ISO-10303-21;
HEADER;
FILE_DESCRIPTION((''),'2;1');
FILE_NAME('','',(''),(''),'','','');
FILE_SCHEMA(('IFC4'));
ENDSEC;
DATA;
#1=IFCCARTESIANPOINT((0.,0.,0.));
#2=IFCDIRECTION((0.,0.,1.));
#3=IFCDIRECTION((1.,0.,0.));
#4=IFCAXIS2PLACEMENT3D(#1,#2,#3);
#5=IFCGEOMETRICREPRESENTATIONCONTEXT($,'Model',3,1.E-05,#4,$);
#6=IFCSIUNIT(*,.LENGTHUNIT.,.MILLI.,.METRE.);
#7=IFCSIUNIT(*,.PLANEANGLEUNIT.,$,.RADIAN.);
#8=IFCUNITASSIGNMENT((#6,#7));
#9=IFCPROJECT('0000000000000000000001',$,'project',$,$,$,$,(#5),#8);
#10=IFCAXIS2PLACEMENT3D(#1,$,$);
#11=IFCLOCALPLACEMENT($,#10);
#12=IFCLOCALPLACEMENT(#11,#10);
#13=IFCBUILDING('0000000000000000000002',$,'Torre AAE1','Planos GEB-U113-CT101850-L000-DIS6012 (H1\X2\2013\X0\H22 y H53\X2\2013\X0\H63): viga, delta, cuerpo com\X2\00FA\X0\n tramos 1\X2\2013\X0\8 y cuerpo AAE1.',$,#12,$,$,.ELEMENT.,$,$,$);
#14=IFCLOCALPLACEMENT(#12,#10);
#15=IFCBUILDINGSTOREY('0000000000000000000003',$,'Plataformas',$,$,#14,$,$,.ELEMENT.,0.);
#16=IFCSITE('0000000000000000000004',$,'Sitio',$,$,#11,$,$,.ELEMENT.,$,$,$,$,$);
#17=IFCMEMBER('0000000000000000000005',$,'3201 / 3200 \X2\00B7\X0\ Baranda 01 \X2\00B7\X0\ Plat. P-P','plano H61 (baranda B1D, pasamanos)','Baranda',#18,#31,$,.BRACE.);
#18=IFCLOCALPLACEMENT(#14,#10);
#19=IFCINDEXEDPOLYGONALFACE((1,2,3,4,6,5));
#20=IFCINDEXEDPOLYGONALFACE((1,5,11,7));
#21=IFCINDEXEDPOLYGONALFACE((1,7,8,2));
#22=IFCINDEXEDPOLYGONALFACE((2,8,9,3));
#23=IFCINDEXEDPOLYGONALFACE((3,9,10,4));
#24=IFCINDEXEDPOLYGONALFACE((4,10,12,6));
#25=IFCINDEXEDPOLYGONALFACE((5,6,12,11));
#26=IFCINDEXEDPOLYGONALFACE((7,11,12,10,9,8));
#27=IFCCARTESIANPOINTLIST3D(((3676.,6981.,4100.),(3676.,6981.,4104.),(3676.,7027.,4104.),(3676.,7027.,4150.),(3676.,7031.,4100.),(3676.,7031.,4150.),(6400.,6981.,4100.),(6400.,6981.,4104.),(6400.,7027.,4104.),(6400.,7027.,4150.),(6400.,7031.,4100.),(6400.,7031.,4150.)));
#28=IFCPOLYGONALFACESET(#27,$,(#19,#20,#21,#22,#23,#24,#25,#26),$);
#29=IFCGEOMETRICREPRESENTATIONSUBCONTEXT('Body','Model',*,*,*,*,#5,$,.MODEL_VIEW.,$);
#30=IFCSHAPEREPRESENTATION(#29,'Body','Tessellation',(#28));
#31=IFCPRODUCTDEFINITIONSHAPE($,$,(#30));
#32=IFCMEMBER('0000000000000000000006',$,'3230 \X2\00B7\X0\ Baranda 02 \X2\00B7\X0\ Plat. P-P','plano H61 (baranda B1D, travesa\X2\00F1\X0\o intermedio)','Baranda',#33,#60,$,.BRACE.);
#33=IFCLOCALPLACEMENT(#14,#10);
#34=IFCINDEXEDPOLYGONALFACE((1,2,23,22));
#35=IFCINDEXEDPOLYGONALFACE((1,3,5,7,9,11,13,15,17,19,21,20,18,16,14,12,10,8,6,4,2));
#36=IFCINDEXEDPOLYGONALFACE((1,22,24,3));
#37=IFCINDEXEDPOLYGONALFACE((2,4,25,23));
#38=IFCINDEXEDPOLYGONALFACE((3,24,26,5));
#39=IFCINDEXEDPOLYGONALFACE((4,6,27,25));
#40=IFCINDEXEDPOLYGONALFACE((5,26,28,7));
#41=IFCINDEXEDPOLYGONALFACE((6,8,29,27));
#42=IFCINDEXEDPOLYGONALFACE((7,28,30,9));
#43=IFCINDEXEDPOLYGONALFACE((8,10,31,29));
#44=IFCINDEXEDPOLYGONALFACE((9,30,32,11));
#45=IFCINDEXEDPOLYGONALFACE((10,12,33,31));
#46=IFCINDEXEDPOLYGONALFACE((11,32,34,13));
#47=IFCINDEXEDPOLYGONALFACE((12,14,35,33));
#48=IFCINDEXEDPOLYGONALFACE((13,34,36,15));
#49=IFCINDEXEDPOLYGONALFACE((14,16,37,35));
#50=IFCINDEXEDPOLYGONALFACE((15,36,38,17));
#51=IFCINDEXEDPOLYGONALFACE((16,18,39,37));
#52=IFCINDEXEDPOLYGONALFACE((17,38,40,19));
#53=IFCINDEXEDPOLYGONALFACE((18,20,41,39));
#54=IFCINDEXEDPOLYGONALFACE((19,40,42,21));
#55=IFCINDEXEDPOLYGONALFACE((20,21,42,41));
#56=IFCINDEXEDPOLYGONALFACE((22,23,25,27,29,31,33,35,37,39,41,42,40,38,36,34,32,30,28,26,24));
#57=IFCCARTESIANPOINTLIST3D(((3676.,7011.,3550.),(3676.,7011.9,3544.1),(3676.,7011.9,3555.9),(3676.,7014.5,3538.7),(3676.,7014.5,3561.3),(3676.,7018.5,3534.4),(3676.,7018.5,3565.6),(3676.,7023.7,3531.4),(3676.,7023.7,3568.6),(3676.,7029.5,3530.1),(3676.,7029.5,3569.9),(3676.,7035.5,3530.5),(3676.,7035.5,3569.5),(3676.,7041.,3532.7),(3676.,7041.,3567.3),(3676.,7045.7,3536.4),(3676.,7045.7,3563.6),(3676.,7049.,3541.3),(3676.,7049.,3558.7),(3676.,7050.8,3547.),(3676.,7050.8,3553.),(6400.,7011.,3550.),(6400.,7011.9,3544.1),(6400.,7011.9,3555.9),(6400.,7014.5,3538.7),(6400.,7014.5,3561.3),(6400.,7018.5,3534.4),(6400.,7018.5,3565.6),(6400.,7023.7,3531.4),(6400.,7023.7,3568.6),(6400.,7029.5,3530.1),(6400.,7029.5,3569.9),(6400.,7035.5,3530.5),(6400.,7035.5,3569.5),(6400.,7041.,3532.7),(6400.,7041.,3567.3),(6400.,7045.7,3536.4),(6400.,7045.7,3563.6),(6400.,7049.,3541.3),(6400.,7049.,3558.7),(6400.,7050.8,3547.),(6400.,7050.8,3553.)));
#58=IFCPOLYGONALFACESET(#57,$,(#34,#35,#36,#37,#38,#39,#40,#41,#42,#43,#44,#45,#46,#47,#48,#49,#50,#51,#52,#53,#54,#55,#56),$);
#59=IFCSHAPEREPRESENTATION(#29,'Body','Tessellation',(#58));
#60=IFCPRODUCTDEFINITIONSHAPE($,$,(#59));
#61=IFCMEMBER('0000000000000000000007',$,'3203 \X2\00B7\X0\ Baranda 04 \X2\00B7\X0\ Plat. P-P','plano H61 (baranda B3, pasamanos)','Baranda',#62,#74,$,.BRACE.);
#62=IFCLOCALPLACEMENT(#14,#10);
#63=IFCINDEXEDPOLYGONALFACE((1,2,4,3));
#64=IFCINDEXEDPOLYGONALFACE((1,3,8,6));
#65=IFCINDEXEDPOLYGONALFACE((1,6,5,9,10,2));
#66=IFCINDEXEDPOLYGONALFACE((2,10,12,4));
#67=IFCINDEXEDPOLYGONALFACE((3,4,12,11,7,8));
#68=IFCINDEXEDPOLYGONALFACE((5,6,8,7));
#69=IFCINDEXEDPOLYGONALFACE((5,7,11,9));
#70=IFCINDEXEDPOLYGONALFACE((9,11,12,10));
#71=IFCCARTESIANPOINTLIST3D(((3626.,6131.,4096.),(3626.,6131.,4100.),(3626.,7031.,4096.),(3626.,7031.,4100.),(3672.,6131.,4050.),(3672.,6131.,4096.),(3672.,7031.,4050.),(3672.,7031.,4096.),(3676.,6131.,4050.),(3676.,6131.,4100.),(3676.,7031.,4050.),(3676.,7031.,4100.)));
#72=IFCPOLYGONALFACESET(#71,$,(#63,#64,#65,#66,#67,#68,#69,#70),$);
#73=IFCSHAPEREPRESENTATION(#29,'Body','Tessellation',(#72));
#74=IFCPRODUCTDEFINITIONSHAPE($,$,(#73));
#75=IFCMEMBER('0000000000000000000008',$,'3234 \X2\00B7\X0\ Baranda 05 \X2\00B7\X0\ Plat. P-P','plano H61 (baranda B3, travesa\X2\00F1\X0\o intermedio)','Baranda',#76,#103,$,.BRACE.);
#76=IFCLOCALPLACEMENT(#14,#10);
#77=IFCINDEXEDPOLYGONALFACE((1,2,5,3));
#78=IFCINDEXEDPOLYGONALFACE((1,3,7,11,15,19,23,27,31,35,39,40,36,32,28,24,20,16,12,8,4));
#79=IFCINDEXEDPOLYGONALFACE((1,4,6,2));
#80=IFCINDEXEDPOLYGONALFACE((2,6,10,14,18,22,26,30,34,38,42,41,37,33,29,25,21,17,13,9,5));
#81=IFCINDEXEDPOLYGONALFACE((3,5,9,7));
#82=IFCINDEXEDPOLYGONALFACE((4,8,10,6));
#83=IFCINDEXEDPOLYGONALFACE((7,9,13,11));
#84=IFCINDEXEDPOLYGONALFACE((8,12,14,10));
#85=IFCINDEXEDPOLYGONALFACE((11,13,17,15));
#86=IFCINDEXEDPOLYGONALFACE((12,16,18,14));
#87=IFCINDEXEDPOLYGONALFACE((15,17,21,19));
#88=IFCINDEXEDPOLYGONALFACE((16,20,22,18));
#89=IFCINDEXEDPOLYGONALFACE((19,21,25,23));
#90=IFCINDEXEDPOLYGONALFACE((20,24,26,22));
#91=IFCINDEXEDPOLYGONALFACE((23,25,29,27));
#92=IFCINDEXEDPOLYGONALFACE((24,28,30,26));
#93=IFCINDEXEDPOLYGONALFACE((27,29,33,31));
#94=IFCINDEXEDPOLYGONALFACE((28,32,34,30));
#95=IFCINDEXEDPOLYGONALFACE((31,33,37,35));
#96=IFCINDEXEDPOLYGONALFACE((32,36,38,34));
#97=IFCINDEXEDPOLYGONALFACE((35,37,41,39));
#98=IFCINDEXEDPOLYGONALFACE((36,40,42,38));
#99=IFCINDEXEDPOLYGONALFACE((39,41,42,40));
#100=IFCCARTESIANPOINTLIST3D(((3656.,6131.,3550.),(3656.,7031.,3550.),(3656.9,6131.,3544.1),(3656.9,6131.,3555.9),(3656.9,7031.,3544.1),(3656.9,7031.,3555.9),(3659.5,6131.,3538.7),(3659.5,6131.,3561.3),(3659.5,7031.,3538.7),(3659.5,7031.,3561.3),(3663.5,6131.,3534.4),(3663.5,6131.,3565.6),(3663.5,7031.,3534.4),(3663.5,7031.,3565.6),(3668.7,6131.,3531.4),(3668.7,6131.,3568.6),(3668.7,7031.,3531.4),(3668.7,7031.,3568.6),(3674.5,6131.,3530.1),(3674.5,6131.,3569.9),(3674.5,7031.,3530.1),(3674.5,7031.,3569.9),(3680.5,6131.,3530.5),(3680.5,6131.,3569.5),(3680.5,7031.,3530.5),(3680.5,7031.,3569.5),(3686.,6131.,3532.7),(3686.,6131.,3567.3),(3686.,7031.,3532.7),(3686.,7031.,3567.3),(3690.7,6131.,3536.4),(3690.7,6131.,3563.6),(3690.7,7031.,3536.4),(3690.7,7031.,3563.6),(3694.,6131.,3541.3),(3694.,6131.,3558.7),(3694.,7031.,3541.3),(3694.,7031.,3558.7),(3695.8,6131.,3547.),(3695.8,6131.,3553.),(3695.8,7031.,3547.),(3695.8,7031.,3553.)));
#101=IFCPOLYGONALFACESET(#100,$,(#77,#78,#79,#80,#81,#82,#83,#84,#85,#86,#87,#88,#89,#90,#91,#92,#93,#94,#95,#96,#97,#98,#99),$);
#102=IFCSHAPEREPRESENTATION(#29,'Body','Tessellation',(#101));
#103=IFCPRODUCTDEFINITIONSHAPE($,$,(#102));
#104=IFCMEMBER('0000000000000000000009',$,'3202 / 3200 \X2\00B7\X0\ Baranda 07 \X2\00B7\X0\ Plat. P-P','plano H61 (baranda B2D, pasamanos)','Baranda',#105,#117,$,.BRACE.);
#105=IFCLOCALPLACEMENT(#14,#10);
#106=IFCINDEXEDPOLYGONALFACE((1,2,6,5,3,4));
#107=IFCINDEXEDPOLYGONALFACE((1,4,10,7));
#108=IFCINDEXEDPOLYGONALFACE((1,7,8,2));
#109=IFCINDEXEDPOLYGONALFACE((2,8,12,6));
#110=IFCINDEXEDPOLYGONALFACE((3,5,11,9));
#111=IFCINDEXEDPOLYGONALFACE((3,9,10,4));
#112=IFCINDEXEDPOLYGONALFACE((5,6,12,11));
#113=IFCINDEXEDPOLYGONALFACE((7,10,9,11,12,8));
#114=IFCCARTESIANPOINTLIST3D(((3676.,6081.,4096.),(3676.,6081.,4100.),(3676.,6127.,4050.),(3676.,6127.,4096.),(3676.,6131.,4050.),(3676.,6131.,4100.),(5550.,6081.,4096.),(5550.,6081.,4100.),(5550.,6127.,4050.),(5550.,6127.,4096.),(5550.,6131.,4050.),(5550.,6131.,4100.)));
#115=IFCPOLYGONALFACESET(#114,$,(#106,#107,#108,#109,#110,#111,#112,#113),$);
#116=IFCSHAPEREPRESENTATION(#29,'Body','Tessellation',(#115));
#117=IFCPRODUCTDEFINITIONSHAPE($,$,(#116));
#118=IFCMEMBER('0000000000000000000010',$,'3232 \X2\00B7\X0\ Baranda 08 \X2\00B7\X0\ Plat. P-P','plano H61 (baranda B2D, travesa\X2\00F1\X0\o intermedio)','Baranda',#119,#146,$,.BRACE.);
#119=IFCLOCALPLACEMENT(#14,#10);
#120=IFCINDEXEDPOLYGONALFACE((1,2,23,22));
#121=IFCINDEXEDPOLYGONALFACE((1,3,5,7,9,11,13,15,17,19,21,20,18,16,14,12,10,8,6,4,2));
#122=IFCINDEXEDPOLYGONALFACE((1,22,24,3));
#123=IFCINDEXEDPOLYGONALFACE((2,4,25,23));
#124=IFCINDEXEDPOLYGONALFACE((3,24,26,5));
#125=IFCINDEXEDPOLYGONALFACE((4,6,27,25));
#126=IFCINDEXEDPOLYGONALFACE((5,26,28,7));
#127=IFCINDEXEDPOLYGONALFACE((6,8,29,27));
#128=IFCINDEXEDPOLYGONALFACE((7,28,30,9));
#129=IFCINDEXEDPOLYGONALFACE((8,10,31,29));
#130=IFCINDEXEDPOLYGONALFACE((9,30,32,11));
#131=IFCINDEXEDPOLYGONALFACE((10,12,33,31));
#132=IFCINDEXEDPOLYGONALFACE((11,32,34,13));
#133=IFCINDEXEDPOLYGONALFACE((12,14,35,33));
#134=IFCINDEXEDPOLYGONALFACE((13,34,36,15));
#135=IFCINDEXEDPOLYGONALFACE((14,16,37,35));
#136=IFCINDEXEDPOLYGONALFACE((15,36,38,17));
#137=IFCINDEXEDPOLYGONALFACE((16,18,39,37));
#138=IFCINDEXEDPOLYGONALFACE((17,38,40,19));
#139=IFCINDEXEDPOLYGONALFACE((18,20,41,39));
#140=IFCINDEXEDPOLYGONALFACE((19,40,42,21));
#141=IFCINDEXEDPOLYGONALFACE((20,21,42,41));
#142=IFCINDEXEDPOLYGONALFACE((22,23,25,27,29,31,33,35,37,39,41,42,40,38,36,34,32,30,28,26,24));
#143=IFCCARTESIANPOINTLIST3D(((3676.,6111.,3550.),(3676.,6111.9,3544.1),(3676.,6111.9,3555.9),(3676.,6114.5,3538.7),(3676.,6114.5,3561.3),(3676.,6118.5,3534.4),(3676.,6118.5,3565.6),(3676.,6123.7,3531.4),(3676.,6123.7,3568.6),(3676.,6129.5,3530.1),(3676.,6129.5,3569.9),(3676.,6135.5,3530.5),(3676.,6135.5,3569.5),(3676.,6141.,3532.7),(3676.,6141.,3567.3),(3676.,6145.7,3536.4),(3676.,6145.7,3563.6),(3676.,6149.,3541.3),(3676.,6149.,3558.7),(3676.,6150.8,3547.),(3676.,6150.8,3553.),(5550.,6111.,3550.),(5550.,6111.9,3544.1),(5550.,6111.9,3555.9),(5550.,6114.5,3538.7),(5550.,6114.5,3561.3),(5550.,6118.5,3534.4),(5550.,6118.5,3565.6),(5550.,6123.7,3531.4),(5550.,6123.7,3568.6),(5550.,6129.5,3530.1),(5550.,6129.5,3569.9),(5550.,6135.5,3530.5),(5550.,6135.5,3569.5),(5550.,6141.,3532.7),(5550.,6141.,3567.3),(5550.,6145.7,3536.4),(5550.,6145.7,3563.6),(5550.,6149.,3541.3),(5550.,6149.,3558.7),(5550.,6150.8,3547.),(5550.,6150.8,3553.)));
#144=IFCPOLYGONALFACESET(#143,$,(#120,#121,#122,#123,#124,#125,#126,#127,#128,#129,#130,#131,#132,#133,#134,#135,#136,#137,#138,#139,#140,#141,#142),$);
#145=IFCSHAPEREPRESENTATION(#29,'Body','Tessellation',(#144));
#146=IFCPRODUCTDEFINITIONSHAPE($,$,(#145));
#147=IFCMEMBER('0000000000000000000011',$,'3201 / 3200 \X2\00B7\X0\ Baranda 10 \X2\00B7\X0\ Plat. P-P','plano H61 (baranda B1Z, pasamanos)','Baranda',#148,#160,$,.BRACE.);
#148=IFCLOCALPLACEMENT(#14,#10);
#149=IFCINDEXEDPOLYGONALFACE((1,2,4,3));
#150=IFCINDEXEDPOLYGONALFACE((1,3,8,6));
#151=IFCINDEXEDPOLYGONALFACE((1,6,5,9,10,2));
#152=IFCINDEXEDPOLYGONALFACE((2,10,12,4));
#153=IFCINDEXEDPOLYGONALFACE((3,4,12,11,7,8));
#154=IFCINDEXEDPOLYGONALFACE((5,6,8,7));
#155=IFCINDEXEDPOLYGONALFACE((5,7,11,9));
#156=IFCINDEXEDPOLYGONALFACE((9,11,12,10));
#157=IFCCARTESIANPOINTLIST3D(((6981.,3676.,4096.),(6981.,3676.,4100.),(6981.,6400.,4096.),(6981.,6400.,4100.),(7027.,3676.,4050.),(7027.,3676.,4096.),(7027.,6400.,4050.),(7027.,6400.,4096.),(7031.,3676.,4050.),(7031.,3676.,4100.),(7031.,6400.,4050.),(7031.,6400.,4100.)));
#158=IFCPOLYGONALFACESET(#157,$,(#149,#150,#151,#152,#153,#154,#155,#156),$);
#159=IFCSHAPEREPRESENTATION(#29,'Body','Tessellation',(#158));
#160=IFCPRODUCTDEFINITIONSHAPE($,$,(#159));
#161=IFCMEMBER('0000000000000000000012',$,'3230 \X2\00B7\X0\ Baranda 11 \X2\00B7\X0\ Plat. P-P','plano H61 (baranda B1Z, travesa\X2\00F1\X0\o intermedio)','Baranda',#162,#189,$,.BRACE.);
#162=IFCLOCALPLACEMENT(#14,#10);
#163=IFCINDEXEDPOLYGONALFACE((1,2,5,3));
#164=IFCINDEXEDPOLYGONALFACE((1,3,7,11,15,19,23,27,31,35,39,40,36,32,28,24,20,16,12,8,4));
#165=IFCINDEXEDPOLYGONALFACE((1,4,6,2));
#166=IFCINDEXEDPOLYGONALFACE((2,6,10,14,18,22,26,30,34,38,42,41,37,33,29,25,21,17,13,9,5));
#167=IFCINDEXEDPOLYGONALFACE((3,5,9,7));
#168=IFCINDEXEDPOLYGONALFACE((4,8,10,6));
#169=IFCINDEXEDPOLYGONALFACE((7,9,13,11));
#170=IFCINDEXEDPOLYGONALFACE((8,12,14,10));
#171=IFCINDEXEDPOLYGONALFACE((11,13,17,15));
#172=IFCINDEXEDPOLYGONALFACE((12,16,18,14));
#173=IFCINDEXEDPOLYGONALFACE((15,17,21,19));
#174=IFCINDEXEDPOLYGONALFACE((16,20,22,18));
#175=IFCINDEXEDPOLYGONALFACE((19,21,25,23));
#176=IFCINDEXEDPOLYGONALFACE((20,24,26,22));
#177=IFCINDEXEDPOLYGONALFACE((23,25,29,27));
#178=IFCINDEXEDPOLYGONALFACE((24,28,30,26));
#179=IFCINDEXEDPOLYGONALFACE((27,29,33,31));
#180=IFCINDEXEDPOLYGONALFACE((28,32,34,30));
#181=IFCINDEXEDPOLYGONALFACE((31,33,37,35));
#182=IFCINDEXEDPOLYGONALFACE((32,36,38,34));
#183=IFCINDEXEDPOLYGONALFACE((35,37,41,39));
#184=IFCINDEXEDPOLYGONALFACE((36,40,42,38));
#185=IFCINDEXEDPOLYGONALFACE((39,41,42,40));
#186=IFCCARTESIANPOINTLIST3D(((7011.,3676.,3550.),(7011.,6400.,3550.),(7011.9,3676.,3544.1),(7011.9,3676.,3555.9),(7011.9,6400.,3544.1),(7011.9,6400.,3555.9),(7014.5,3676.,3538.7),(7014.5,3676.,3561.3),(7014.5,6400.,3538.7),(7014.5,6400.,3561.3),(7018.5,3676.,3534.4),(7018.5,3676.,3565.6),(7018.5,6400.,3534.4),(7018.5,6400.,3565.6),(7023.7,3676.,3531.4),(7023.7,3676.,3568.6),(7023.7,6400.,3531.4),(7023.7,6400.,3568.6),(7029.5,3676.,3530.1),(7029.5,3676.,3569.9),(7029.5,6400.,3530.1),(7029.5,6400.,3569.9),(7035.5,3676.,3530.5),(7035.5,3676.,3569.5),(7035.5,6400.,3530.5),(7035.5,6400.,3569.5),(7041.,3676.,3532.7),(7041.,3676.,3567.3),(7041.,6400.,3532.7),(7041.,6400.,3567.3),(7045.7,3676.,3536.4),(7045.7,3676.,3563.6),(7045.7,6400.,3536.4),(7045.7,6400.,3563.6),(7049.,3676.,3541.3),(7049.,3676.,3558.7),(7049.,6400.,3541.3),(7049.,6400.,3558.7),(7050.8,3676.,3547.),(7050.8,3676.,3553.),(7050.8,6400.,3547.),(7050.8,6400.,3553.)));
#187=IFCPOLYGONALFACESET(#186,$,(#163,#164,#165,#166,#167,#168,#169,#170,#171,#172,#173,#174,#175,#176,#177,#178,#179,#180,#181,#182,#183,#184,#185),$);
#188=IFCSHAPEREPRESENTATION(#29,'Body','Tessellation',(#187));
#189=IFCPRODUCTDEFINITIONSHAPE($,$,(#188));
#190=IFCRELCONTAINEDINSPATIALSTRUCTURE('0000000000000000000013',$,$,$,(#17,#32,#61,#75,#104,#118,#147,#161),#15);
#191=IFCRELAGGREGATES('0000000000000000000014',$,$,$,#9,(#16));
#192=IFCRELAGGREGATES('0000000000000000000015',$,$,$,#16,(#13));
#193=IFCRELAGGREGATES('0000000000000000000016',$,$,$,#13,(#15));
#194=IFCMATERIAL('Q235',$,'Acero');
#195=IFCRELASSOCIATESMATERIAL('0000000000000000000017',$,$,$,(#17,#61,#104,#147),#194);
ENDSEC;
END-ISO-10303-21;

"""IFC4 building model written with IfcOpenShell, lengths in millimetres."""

from ifc_helpers import new_model, si_unit, frame, frame_2d, origin, origin_with_axes, place, context, subcontext, project, spatial, circle, l_section, extrude, material, element, save


model = new_model("IFC4")

# Units and contexts
model_context = context("Model", 3, precision=1e-05, world=origin_with_axes())
body_context = subcontext(model_context, "Body", "Model", "MODEL_VIEW")
ifc_project = project(units=[si_unit("LENGTHUNIT", "METRE", prefix="MILLI"), si_unit("PLANEANGLEUNIT", "RADIAN")], contexts=[model_context])

# Site, building, storey
site_placement = place(None, origin())
site = spatial("IfcSite", under=ifc_project, at=site_placement, Name="Sitio", CompositionType="ELEMENT")
building_placement = place(site_placement, origin())
building = spatial("IfcBuilding", under=site, at=building_placement, Name="Torre AAE1", Description="Planos GEB-U113-CT101850-L000-DIS6012 (H1–H22 y H53–H63): viga, delta, cuerpo común tramos 1–8 y cuerpo AAE1.", CompositionType="ELEMENT")
storey_placement = place(building_placement, origin())
storey = spatial("IfcBuildingStorey", under=building, at=storey_placement, Name="Plataformas", CompositionType="ELEMENT", Elevation=0.0)

# Members
ifc_material = material(Name="Q235", Category="Acero")
member_1_placement = place(storey_placement, frame((6400.0, 7031.0, 4100.0), z_axis=(-1.0, 0.0, 0.0), x_axis=(0.0, -1.0, 0.0)))
element("IfcMember", 1, at=member_1_placement, inside=storey, material=ifc_material, Name="3201 / 3200 · Baranda 01 · Plat. P-P", Description="plano H61 (baranda B1D, pasamanos)", ObjectType="Baranda", PredefinedType="BRACE", context=body_context, shape_type="SweptSolid", body=[
    extrude(l_section(Depth=50.0, Width=50.0, Thickness=4.0, at=frame_2d((25.0, 25.0))), None, (0.0, 0.0, 1.0), 2724.0),
])
member_2_placement = place(storey_placement, frame((6400.0, 7031.0, 3550.0), z_axis=(-1.0, 0.0, 0.0), x_axis=(0.0, -1.0, 0.0)))
element("IfcMember", 2, at=member_2_placement, inside=storey, Name="3230 · Baranda 02 · Plat. P-P", Description="plano H61 (baranda B1D, travesaño intermedio)", ObjectType="Baranda", PredefinedType="BRACE", context=body_context, shape_type="SweptSolid", body=[
    extrude(circle(Radius=20.0), None, (0.0, 0.0, 1.0), 2724.0),
])
member_3_placement = place(storey_placement, frame((3676.0, 7031.0, 4100.0), z_axis=(0.0, -1.0, 0.0), x_axis=(-1.0, 0.0, 0.0)))
element("IfcMember", 3, at=member_3_placement, inside=storey, material=ifc_material, Name="3203 · Baranda 04 · Plat. P-P", Description="plano H61 (baranda B3, pasamanos)", ObjectType="Baranda", PredefinedType="BRACE", context=body_context, shape_type="SweptSolid", body=[
    extrude(l_section(Depth=50.0, Width=50.0, Thickness=4.0, at=frame_2d((25.0, 25.0))), None, (0.0, 0.0, 1.0), 900.0),
])
member_4_placement = place(storey_placement, frame((3676.0, 7031.0, 3550.0), z_axis=(0.0, -1.0, 0.0), x_axis=(-1.0, 0.0, 0.0)))
element("IfcMember", 4, at=member_4_placement, inside=storey, Name="3234 · Baranda 05 · Plat. P-P", Description="plano H61 (baranda B3, travesaño intermedio)", ObjectType="Baranda", PredefinedType="BRACE", context=body_context, shape_type="SweptSolid", body=[
    extrude(circle(Radius=20.0), None, (0.0, 0.0, 1.0), 900.0),
])
member_5_placement = place(storey_placement, frame((3676.0, 6131.0, 4100.0), z_axis=(1.0, 0.0, 0.0), x_axis=(0.0, -1.0, 0.0)))
element("IfcMember", 5, at=member_5_placement, inside=storey, material=ifc_material, Name="3202 / 3200 · Baranda 07 · Plat. P-P", Description="plano H61 (baranda B2D, pasamanos)", ObjectType="Baranda", PredefinedType="BRACE", context=body_context, shape_type="SweptSolid", body=[
    extrude(l_section(Depth=50.0, Width=50.0, Thickness=4.0, at=frame_2d((25.0, 25.0))), None, (0.0, 0.0, 1.0), 1874.0),
])
member_6_placement = place(storey_placement, frame((3676.0, 6131.0, 3550.0), z_axis=(1.0, 0.0, 0.0), x_axis=(0.0, -1.0, 0.0)))
element("IfcMember", 6, at=member_6_placement, inside=storey, Name="3232 · Baranda 08 · Plat. P-P", Description="plano H61 (baranda B2D, travesaño intermedio)", ObjectType="Baranda", PredefinedType="BRACE", context=body_context, shape_type="SweptSolid", body=[
    extrude(circle(Radius=20.0), None, (0.0, 0.0, 1.0), 1874.0),
])
member_7_placement = place(storey_placement, frame((7031.0, 6400.0, 4100.0), z_axis=(0.0, -1.0, 0.0), x_axis=(-1.0, 0.0, 0.0)))
element("IfcMember", 7, at=member_7_placement, inside=storey, material=ifc_material, Name="3201 / 3200 · Baranda 10 · Plat. P-P", Description="plano H61 (baranda B1Z, pasamanos)", ObjectType="Baranda", PredefinedType="BRACE", context=body_context, shape_type="SweptSolid", body=[
    extrude(l_section(Depth=50.0, Width=50.0, Thickness=4.0, at=frame_2d((25.0, 25.0))), None, (0.0, 0.0, 1.0), 2724.0),
])
for number, where, z_axis, x_axis, name in (
    (8, (7031.0, 6400.0, 3550.0), (0.0, -1.0, 0.0), (-1.0, 0.0, 0.0), "3230 · Baranda 11 · Plat. P-P"),
):
    element("IfcMember", number, at=place(storey_placement, frame(where, z_axis=z_axis, x_axis=x_axis)), inside=storey, Name=name, Description="plano H61 (baranda B1Z, travesaño intermedio)", ObjectType="Baranda", PredefinedType="BRACE", context=body_context, shape_type="SweptSolid", body=[
        extrude(circle(Radius=20.0), None, (0.0, 0.0, 1.0), 2724.0),
    ])

save(model, "model.ifc")
